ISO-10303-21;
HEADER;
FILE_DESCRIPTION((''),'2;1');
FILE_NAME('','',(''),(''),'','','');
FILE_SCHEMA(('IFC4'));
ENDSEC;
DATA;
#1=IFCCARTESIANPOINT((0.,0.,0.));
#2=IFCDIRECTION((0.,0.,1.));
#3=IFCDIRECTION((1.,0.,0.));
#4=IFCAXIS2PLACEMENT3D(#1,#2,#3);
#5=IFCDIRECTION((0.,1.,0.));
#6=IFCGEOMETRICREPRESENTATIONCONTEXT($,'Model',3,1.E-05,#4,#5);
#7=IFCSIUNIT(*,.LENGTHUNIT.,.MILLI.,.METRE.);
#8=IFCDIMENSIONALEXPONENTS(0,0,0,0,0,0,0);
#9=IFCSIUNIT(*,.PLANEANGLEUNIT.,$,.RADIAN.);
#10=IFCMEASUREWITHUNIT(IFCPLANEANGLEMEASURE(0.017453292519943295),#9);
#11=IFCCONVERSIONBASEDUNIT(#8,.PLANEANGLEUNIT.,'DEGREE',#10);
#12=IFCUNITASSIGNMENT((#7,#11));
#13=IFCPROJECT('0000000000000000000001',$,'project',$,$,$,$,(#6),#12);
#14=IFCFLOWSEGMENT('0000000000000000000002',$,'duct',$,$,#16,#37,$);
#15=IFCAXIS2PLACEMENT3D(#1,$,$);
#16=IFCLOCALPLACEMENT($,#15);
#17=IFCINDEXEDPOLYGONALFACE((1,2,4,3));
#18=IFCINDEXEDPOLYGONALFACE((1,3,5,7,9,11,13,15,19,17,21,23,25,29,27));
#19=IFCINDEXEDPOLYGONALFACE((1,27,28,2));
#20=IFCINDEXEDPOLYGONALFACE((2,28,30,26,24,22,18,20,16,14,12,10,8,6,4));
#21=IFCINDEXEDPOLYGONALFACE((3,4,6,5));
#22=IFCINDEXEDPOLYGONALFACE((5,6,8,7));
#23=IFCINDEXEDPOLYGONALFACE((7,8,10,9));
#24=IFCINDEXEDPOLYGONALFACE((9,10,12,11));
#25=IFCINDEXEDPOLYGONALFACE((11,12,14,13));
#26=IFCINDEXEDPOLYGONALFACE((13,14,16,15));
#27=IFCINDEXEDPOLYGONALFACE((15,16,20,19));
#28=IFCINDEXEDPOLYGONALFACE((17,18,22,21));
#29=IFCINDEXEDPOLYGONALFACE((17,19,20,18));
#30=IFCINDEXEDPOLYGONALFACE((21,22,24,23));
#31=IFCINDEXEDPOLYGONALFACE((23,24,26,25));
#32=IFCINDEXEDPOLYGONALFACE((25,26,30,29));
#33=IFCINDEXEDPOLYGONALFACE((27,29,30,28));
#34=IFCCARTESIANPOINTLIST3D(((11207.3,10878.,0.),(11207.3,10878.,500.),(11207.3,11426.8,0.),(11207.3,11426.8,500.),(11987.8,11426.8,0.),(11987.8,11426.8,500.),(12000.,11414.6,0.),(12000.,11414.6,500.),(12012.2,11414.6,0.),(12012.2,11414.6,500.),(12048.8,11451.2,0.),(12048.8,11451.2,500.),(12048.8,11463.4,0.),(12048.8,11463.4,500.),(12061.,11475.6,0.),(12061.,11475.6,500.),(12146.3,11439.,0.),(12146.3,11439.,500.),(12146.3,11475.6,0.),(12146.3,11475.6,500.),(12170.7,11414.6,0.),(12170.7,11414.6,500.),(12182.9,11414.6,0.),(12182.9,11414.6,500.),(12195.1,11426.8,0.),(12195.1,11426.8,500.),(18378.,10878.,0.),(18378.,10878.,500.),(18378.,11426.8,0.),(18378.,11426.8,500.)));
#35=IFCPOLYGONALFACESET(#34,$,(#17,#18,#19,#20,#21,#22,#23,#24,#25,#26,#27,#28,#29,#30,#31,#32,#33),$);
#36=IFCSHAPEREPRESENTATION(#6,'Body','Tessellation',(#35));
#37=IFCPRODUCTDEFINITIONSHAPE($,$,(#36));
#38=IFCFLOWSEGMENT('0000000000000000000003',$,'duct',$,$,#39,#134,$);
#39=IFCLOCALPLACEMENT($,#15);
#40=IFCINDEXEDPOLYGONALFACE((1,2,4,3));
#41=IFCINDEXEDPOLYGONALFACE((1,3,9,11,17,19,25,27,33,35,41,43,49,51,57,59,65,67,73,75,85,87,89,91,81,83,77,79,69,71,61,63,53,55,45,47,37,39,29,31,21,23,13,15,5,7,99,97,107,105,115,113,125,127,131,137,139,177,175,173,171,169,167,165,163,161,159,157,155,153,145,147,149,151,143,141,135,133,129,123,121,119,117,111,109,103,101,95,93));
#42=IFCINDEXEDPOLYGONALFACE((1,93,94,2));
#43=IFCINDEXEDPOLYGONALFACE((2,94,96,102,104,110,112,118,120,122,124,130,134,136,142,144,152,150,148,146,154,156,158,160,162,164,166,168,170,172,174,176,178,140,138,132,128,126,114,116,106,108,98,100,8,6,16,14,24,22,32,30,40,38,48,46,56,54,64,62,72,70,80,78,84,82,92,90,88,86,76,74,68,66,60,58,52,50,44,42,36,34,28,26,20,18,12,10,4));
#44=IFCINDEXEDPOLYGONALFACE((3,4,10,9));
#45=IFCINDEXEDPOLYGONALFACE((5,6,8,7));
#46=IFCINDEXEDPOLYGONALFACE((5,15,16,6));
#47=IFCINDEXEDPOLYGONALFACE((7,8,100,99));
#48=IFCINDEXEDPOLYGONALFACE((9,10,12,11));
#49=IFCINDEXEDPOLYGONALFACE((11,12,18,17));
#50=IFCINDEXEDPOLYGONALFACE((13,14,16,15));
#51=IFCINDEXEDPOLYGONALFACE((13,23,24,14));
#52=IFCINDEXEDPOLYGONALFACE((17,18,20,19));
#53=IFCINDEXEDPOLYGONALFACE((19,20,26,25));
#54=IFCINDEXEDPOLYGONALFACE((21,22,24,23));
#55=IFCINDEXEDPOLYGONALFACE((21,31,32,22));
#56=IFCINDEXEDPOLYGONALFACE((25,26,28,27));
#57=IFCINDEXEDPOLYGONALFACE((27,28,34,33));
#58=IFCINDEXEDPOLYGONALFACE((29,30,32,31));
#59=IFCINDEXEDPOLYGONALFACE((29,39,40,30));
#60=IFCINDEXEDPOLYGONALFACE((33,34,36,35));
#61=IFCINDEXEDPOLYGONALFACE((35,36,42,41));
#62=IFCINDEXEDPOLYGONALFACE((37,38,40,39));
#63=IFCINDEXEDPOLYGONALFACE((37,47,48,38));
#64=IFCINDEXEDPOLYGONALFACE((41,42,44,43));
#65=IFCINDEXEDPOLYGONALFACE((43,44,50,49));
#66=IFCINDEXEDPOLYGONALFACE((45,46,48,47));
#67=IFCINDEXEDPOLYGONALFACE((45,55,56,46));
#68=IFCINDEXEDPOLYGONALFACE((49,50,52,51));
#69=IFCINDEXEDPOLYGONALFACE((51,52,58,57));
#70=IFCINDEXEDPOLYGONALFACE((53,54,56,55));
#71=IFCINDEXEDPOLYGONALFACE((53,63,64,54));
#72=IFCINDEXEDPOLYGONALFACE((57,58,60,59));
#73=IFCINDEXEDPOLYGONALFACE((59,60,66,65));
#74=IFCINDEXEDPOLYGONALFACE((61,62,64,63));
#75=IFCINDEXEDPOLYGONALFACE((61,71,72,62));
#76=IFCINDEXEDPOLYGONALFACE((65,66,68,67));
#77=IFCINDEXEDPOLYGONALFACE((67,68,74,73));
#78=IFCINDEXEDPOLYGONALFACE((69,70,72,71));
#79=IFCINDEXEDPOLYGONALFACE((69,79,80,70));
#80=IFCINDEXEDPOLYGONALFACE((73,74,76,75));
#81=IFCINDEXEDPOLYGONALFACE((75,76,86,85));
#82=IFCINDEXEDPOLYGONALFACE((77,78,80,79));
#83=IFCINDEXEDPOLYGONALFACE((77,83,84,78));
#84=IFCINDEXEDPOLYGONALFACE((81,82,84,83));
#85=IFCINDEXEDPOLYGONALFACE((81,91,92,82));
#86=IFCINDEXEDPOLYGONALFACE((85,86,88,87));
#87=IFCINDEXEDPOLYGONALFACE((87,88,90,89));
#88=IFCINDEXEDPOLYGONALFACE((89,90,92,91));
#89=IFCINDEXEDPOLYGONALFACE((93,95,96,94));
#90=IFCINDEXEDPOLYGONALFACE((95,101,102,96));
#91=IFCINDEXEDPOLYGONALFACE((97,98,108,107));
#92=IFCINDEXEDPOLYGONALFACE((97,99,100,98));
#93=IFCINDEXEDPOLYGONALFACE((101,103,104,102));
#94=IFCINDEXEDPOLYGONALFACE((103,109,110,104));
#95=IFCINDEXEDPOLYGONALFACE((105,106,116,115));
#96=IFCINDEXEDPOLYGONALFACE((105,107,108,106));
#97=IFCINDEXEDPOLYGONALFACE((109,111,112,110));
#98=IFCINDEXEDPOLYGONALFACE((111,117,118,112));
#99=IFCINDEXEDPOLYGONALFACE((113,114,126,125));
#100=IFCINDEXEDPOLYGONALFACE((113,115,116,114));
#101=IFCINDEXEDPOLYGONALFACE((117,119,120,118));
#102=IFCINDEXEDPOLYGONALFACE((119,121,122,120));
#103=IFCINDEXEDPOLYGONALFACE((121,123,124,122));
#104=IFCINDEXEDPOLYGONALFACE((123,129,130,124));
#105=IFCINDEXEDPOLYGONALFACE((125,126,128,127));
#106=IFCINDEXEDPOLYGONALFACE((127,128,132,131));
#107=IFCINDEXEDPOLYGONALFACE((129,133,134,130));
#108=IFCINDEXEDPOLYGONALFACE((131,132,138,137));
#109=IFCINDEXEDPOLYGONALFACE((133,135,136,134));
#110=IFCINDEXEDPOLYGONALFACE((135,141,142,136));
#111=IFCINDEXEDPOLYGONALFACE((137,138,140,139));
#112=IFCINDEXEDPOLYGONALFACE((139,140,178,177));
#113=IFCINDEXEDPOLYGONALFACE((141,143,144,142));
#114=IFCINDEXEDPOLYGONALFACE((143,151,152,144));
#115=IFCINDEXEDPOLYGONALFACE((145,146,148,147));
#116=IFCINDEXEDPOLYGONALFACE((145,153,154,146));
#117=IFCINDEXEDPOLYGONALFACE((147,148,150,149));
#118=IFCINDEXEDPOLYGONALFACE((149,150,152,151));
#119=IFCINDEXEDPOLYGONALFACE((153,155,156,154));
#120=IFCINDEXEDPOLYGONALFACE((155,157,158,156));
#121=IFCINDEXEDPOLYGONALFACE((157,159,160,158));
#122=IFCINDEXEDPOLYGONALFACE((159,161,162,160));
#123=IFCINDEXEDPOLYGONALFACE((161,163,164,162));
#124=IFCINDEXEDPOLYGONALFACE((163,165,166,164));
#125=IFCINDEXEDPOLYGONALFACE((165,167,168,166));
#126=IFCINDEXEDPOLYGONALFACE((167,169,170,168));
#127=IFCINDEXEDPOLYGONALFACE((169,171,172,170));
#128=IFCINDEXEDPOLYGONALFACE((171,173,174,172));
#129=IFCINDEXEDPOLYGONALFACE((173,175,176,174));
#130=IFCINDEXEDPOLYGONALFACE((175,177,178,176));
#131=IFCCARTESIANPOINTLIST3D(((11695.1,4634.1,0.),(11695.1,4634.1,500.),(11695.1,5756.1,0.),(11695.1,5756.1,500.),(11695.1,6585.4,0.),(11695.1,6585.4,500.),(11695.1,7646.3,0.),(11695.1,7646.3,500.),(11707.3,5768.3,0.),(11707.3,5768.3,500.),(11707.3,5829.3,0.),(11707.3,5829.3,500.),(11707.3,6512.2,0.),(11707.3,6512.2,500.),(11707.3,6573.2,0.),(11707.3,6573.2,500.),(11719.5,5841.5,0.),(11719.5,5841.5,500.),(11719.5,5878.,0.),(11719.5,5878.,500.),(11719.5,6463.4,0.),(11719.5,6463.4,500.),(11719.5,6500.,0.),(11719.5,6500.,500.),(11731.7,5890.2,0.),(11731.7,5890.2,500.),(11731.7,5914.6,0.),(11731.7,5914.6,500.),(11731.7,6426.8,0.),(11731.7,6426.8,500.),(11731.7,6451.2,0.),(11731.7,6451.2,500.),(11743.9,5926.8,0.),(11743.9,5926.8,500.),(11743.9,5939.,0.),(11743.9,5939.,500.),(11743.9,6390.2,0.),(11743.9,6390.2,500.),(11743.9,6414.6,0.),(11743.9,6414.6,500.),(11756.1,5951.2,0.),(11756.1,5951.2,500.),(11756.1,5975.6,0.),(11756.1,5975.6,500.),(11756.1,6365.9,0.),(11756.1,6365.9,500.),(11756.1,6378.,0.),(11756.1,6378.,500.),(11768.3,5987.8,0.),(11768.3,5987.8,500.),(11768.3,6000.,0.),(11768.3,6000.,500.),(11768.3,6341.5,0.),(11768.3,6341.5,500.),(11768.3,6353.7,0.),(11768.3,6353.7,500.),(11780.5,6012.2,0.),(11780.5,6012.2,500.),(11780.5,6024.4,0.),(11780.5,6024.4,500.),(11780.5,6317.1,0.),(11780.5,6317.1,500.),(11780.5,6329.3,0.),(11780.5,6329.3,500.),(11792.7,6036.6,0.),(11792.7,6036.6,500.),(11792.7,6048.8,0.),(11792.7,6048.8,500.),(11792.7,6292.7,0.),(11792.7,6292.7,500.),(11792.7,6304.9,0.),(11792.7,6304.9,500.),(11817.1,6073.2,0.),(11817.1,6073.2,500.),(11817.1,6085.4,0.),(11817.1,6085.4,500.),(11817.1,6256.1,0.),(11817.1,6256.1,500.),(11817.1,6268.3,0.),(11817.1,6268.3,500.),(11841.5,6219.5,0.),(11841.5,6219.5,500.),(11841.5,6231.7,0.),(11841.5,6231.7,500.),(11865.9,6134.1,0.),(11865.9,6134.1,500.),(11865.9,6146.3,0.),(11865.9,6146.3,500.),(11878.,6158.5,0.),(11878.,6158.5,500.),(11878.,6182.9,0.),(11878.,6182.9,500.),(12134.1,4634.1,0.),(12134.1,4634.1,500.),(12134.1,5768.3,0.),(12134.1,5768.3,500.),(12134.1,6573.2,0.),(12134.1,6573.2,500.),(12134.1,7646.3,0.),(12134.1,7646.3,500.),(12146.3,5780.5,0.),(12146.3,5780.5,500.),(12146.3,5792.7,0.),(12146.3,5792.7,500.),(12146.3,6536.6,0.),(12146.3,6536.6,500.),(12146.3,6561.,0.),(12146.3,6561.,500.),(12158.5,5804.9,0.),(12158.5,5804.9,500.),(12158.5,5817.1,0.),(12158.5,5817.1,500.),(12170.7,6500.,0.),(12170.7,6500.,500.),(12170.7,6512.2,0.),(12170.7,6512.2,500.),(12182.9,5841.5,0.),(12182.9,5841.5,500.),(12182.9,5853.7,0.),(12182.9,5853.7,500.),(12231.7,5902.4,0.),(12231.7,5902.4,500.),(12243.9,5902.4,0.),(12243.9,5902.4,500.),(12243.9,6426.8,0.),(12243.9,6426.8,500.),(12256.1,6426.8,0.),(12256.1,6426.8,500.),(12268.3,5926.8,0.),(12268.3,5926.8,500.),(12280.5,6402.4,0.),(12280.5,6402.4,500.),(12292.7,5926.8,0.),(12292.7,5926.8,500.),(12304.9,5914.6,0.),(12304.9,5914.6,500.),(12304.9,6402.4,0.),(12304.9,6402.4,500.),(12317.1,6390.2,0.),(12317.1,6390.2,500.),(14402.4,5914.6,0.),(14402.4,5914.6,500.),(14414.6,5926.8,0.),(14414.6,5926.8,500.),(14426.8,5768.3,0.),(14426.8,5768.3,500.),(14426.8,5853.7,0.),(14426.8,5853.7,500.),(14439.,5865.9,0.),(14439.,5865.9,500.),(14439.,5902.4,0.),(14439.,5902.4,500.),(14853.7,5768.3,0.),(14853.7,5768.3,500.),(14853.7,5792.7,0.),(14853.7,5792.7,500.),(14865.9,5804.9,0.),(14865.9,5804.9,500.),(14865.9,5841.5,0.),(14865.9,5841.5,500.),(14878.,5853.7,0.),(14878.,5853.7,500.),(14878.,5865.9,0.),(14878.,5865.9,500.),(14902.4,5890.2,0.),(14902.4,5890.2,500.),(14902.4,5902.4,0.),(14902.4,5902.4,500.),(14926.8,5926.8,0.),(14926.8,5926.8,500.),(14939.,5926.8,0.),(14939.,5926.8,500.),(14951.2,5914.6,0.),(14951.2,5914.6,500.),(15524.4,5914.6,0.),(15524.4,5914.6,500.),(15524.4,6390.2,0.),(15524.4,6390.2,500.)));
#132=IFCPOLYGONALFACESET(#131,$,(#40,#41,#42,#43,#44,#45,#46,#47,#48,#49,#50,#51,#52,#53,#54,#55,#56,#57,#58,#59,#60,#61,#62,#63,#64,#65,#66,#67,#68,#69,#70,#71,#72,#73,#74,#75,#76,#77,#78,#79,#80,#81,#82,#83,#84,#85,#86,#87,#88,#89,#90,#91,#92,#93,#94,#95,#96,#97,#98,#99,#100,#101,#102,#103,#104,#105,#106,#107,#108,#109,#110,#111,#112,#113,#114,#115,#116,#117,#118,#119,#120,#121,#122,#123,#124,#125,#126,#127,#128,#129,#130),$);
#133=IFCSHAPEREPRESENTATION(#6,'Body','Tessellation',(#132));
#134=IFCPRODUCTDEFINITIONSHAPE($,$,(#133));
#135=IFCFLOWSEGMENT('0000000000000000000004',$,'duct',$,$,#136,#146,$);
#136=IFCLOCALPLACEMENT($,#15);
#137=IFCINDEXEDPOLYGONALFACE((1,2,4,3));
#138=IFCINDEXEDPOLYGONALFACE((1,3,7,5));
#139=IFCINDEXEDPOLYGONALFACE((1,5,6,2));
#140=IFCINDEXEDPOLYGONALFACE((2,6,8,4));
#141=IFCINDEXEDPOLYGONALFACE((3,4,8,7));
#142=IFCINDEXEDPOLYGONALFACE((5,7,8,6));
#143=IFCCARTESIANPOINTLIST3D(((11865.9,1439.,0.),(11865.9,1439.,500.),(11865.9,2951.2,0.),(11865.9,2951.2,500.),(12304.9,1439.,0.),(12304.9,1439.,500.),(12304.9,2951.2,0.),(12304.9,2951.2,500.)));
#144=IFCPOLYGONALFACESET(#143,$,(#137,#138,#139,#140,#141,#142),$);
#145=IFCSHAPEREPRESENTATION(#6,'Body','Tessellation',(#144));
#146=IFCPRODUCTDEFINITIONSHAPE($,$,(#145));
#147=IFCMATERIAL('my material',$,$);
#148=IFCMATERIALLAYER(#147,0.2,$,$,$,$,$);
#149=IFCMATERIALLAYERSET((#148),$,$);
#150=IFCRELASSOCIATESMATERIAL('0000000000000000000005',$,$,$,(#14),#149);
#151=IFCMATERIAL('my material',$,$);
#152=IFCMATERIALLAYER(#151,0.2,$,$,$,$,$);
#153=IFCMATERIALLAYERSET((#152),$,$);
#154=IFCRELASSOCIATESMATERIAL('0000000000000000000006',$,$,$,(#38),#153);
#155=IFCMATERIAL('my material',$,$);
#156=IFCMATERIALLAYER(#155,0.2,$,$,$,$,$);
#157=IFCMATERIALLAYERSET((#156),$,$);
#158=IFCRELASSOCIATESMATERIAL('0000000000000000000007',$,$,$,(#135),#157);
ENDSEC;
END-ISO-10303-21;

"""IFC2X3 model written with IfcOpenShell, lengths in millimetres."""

from ifc_helpers import new_model, entity, si_unit, converted_unit, direction, origin_with_axes, place, context, project, polyline, outline, extrude, material, layer, layer_set, layer_usage, element, save


model = new_model("IFC2X3")

# Units and contexts
model_context = context("Model", 3, precision=1e-05, world=origin_with_axes(), true_north=direction((0.0, 1.0, 0.0)))
ifc_project = project(units=[si_unit("LENGTHUNIT", "METRE", prefix="MILLI"), converted_unit("PLANEANGLEUNIT", "DEGREE", entity("IfcPlaneAngleMeasure", 0.017453292519943295), si_unit("PLANEANGLEUNIT", "RADIAN"), dimensions=[0, 0, 0, 0, 0, 0, 0])], contexts=[model_context])

# Flow segments
ifc_material_1 = material(Name="my material")
ifc_layer_1 = layer(ifc_material_1, 0.2)
ifc_layer_set_1 = layer_set([ifc_layer_1])
ifc_layer_usage_1 = layer_usage(ifc_layer_set_1, "AXIS2", "POSITIVE", -0.1)
flow_segment_1_placement = place(None, origin_with_axes())
element("IfcFlowSegment", 1, at=flow_segment_1_placement, material=ifc_layer_usage_1, Name="duct", context=model_context, shape_type="SweptSolid", body=[
    extrude(outline(polyline([(11207.3, 10878.0), (18378.0, 10878.0), (18378.0, 11426.8), (12195.1, 11426.8), (12182.9, 11414.6), (12170.7, 11414.6), (12146.3, 11439.0), (12146.3, 11475.6), (12061.0, 11475.6), (12048.8, 11463.4), (12048.8, 11451.2), (12012.2, 11414.6), (12000.0, 11414.6), (11987.8, 11426.8), (11207.3, 11426.8), (11207.3, 10878.0)])), origin_with_axes(), (0.0, 0.0, 1.0), 500.0),
])
ifc_material_2 = material(Name="my material")
ifc_layer_2 = layer(ifc_material_2, 0.2)
ifc_layer_set_2 = layer_set([ifc_layer_2])
ifc_layer_usage_2 = layer_usage(ifc_layer_set_2, "AXIS2", "POSITIVE", -0.1)
flow_segment_2_placement = place(None, origin_with_axes())
element("IfcFlowSegment", 2, at=flow_segment_2_placement, material=ifc_layer_usage_2, Name="duct", context=model_context, shape_type="SweptSolid", body=[
    extrude(outline(polyline([(11695.1, 4634.1), (12134.1, 4634.1), (12134.1, 5768.3), (12146.3, 5780.5), (12146.3, 5792.7), (12158.5, 5804.9), (12158.5, 5817.1), (12182.9, 5841.5), (12182.9, 5853.7), (12231.7, 5902.4), (12243.9, 5902.4), (12268.3, 5926.8), (12292.7, 5926.8), (12304.9, 5914.6), (14402.4, 5914.6), (14414.6, 5926.8), (14439.0, 5902.4), (14439.0, 5865.9), (14426.8, 5853.7), (14426.8, 5768.3), (14853.7, 5768.3), (14853.7, 5792.7), (14865.9, 5804.9), (14865.9, 5841.5), (14878.0, 5853.7), (14878.0, 5865.9), (14902.4, 5890.2), (14902.4, 5902.4), (14926.8, 5926.8), (14939.0, 5926.8), (14951.2, 5914.6), (15524.4, 5914.6), (15524.4, 6390.2), (12317.1, 6390.2), (12304.9, 6402.4), (12280.5, 6402.4), (12256.1, 6426.8), (12243.9, 6426.8), (12170.7, 6500.0), (12170.7, 6512.2), (12146.3, 6536.6), (12146.3, 6561.0), (12134.1, 6573.2), (12134.1, 7646.3), (11695.1, 7646.3), (11695.1, 6585.4), (11707.3, 6573.2), (11707.3, 6512.2), (11719.5, 6500.0), (11719.5, 6463.4), (11731.7, 6451.2), (11731.7, 6426.8), (11743.9, 6414.6), (11743.9, 6390.2), (11756.1, 6378.0), (11756.1, 6365.9), (11768.3, 6353.7), (11768.3, 6341.5), (11780.5, 6329.3), (11780.5, 6317.1), (11792.7, 6304.9), (11792.7, 6292.7), (11817.1, 6268.3), (11817.1, 6256.1), (11841.5, 6231.7), (11841.5, 6219.5), (11878.0, 6182.9), (11878.0, 6158.5), (11865.9, 6146.3), (11865.9, 6134.1), (11817.1, 6085.4), (11817.1, 6073.2), (11792.7, 6048.8), (11792.7, 6036.6), (11780.5, 6024.4), (11780.5, 6012.2), (11768.3, 6000.0), (11768.3, 5987.8), (11756.1, 5975.6), (11756.1, 5951.2), (11743.9, 5939.0), (11743.9, 5926.8), (11731.7, 5914.6), (11731.7, 5890.2), (11719.5, 5878.0), (11719.5, 5841.5), (11707.3, 5829.3), (11707.3, 5768.3), (11695.1, 5756.1), (11695.1, 4634.1)])), origin_with_axes(), (0.0, 0.0, 1.0), 500.0),
])
ifc_material_3 = material(Name="my material")
ifc_layer_3 = layer(ifc_material_3, 0.2)
ifc_layer_set_3 = layer_set([ifc_layer_3])
ifc_layer_usage_3 = layer_usage(ifc_layer_set_3, "AXIS2", "POSITIVE", -0.1)
flow_segment_3_placement = place(None, origin_with_axes())
element("IfcFlowSegment", 3, at=flow_segment_3_placement, material=ifc_layer_usage_3, Name="duct", context=model_context, shape_type="SweptSolid", body=[
    extrude(outline(polyline([(11865.9, 1439.0), (12304.9, 1439.0), (12304.9, 2951.2), (11865.9, 2951.2), (11865.9, 1439.0)])), origin_with_axes(), (0.0, 0.0, 1.0), 500.0),
])

save(model, "model.ifc")
